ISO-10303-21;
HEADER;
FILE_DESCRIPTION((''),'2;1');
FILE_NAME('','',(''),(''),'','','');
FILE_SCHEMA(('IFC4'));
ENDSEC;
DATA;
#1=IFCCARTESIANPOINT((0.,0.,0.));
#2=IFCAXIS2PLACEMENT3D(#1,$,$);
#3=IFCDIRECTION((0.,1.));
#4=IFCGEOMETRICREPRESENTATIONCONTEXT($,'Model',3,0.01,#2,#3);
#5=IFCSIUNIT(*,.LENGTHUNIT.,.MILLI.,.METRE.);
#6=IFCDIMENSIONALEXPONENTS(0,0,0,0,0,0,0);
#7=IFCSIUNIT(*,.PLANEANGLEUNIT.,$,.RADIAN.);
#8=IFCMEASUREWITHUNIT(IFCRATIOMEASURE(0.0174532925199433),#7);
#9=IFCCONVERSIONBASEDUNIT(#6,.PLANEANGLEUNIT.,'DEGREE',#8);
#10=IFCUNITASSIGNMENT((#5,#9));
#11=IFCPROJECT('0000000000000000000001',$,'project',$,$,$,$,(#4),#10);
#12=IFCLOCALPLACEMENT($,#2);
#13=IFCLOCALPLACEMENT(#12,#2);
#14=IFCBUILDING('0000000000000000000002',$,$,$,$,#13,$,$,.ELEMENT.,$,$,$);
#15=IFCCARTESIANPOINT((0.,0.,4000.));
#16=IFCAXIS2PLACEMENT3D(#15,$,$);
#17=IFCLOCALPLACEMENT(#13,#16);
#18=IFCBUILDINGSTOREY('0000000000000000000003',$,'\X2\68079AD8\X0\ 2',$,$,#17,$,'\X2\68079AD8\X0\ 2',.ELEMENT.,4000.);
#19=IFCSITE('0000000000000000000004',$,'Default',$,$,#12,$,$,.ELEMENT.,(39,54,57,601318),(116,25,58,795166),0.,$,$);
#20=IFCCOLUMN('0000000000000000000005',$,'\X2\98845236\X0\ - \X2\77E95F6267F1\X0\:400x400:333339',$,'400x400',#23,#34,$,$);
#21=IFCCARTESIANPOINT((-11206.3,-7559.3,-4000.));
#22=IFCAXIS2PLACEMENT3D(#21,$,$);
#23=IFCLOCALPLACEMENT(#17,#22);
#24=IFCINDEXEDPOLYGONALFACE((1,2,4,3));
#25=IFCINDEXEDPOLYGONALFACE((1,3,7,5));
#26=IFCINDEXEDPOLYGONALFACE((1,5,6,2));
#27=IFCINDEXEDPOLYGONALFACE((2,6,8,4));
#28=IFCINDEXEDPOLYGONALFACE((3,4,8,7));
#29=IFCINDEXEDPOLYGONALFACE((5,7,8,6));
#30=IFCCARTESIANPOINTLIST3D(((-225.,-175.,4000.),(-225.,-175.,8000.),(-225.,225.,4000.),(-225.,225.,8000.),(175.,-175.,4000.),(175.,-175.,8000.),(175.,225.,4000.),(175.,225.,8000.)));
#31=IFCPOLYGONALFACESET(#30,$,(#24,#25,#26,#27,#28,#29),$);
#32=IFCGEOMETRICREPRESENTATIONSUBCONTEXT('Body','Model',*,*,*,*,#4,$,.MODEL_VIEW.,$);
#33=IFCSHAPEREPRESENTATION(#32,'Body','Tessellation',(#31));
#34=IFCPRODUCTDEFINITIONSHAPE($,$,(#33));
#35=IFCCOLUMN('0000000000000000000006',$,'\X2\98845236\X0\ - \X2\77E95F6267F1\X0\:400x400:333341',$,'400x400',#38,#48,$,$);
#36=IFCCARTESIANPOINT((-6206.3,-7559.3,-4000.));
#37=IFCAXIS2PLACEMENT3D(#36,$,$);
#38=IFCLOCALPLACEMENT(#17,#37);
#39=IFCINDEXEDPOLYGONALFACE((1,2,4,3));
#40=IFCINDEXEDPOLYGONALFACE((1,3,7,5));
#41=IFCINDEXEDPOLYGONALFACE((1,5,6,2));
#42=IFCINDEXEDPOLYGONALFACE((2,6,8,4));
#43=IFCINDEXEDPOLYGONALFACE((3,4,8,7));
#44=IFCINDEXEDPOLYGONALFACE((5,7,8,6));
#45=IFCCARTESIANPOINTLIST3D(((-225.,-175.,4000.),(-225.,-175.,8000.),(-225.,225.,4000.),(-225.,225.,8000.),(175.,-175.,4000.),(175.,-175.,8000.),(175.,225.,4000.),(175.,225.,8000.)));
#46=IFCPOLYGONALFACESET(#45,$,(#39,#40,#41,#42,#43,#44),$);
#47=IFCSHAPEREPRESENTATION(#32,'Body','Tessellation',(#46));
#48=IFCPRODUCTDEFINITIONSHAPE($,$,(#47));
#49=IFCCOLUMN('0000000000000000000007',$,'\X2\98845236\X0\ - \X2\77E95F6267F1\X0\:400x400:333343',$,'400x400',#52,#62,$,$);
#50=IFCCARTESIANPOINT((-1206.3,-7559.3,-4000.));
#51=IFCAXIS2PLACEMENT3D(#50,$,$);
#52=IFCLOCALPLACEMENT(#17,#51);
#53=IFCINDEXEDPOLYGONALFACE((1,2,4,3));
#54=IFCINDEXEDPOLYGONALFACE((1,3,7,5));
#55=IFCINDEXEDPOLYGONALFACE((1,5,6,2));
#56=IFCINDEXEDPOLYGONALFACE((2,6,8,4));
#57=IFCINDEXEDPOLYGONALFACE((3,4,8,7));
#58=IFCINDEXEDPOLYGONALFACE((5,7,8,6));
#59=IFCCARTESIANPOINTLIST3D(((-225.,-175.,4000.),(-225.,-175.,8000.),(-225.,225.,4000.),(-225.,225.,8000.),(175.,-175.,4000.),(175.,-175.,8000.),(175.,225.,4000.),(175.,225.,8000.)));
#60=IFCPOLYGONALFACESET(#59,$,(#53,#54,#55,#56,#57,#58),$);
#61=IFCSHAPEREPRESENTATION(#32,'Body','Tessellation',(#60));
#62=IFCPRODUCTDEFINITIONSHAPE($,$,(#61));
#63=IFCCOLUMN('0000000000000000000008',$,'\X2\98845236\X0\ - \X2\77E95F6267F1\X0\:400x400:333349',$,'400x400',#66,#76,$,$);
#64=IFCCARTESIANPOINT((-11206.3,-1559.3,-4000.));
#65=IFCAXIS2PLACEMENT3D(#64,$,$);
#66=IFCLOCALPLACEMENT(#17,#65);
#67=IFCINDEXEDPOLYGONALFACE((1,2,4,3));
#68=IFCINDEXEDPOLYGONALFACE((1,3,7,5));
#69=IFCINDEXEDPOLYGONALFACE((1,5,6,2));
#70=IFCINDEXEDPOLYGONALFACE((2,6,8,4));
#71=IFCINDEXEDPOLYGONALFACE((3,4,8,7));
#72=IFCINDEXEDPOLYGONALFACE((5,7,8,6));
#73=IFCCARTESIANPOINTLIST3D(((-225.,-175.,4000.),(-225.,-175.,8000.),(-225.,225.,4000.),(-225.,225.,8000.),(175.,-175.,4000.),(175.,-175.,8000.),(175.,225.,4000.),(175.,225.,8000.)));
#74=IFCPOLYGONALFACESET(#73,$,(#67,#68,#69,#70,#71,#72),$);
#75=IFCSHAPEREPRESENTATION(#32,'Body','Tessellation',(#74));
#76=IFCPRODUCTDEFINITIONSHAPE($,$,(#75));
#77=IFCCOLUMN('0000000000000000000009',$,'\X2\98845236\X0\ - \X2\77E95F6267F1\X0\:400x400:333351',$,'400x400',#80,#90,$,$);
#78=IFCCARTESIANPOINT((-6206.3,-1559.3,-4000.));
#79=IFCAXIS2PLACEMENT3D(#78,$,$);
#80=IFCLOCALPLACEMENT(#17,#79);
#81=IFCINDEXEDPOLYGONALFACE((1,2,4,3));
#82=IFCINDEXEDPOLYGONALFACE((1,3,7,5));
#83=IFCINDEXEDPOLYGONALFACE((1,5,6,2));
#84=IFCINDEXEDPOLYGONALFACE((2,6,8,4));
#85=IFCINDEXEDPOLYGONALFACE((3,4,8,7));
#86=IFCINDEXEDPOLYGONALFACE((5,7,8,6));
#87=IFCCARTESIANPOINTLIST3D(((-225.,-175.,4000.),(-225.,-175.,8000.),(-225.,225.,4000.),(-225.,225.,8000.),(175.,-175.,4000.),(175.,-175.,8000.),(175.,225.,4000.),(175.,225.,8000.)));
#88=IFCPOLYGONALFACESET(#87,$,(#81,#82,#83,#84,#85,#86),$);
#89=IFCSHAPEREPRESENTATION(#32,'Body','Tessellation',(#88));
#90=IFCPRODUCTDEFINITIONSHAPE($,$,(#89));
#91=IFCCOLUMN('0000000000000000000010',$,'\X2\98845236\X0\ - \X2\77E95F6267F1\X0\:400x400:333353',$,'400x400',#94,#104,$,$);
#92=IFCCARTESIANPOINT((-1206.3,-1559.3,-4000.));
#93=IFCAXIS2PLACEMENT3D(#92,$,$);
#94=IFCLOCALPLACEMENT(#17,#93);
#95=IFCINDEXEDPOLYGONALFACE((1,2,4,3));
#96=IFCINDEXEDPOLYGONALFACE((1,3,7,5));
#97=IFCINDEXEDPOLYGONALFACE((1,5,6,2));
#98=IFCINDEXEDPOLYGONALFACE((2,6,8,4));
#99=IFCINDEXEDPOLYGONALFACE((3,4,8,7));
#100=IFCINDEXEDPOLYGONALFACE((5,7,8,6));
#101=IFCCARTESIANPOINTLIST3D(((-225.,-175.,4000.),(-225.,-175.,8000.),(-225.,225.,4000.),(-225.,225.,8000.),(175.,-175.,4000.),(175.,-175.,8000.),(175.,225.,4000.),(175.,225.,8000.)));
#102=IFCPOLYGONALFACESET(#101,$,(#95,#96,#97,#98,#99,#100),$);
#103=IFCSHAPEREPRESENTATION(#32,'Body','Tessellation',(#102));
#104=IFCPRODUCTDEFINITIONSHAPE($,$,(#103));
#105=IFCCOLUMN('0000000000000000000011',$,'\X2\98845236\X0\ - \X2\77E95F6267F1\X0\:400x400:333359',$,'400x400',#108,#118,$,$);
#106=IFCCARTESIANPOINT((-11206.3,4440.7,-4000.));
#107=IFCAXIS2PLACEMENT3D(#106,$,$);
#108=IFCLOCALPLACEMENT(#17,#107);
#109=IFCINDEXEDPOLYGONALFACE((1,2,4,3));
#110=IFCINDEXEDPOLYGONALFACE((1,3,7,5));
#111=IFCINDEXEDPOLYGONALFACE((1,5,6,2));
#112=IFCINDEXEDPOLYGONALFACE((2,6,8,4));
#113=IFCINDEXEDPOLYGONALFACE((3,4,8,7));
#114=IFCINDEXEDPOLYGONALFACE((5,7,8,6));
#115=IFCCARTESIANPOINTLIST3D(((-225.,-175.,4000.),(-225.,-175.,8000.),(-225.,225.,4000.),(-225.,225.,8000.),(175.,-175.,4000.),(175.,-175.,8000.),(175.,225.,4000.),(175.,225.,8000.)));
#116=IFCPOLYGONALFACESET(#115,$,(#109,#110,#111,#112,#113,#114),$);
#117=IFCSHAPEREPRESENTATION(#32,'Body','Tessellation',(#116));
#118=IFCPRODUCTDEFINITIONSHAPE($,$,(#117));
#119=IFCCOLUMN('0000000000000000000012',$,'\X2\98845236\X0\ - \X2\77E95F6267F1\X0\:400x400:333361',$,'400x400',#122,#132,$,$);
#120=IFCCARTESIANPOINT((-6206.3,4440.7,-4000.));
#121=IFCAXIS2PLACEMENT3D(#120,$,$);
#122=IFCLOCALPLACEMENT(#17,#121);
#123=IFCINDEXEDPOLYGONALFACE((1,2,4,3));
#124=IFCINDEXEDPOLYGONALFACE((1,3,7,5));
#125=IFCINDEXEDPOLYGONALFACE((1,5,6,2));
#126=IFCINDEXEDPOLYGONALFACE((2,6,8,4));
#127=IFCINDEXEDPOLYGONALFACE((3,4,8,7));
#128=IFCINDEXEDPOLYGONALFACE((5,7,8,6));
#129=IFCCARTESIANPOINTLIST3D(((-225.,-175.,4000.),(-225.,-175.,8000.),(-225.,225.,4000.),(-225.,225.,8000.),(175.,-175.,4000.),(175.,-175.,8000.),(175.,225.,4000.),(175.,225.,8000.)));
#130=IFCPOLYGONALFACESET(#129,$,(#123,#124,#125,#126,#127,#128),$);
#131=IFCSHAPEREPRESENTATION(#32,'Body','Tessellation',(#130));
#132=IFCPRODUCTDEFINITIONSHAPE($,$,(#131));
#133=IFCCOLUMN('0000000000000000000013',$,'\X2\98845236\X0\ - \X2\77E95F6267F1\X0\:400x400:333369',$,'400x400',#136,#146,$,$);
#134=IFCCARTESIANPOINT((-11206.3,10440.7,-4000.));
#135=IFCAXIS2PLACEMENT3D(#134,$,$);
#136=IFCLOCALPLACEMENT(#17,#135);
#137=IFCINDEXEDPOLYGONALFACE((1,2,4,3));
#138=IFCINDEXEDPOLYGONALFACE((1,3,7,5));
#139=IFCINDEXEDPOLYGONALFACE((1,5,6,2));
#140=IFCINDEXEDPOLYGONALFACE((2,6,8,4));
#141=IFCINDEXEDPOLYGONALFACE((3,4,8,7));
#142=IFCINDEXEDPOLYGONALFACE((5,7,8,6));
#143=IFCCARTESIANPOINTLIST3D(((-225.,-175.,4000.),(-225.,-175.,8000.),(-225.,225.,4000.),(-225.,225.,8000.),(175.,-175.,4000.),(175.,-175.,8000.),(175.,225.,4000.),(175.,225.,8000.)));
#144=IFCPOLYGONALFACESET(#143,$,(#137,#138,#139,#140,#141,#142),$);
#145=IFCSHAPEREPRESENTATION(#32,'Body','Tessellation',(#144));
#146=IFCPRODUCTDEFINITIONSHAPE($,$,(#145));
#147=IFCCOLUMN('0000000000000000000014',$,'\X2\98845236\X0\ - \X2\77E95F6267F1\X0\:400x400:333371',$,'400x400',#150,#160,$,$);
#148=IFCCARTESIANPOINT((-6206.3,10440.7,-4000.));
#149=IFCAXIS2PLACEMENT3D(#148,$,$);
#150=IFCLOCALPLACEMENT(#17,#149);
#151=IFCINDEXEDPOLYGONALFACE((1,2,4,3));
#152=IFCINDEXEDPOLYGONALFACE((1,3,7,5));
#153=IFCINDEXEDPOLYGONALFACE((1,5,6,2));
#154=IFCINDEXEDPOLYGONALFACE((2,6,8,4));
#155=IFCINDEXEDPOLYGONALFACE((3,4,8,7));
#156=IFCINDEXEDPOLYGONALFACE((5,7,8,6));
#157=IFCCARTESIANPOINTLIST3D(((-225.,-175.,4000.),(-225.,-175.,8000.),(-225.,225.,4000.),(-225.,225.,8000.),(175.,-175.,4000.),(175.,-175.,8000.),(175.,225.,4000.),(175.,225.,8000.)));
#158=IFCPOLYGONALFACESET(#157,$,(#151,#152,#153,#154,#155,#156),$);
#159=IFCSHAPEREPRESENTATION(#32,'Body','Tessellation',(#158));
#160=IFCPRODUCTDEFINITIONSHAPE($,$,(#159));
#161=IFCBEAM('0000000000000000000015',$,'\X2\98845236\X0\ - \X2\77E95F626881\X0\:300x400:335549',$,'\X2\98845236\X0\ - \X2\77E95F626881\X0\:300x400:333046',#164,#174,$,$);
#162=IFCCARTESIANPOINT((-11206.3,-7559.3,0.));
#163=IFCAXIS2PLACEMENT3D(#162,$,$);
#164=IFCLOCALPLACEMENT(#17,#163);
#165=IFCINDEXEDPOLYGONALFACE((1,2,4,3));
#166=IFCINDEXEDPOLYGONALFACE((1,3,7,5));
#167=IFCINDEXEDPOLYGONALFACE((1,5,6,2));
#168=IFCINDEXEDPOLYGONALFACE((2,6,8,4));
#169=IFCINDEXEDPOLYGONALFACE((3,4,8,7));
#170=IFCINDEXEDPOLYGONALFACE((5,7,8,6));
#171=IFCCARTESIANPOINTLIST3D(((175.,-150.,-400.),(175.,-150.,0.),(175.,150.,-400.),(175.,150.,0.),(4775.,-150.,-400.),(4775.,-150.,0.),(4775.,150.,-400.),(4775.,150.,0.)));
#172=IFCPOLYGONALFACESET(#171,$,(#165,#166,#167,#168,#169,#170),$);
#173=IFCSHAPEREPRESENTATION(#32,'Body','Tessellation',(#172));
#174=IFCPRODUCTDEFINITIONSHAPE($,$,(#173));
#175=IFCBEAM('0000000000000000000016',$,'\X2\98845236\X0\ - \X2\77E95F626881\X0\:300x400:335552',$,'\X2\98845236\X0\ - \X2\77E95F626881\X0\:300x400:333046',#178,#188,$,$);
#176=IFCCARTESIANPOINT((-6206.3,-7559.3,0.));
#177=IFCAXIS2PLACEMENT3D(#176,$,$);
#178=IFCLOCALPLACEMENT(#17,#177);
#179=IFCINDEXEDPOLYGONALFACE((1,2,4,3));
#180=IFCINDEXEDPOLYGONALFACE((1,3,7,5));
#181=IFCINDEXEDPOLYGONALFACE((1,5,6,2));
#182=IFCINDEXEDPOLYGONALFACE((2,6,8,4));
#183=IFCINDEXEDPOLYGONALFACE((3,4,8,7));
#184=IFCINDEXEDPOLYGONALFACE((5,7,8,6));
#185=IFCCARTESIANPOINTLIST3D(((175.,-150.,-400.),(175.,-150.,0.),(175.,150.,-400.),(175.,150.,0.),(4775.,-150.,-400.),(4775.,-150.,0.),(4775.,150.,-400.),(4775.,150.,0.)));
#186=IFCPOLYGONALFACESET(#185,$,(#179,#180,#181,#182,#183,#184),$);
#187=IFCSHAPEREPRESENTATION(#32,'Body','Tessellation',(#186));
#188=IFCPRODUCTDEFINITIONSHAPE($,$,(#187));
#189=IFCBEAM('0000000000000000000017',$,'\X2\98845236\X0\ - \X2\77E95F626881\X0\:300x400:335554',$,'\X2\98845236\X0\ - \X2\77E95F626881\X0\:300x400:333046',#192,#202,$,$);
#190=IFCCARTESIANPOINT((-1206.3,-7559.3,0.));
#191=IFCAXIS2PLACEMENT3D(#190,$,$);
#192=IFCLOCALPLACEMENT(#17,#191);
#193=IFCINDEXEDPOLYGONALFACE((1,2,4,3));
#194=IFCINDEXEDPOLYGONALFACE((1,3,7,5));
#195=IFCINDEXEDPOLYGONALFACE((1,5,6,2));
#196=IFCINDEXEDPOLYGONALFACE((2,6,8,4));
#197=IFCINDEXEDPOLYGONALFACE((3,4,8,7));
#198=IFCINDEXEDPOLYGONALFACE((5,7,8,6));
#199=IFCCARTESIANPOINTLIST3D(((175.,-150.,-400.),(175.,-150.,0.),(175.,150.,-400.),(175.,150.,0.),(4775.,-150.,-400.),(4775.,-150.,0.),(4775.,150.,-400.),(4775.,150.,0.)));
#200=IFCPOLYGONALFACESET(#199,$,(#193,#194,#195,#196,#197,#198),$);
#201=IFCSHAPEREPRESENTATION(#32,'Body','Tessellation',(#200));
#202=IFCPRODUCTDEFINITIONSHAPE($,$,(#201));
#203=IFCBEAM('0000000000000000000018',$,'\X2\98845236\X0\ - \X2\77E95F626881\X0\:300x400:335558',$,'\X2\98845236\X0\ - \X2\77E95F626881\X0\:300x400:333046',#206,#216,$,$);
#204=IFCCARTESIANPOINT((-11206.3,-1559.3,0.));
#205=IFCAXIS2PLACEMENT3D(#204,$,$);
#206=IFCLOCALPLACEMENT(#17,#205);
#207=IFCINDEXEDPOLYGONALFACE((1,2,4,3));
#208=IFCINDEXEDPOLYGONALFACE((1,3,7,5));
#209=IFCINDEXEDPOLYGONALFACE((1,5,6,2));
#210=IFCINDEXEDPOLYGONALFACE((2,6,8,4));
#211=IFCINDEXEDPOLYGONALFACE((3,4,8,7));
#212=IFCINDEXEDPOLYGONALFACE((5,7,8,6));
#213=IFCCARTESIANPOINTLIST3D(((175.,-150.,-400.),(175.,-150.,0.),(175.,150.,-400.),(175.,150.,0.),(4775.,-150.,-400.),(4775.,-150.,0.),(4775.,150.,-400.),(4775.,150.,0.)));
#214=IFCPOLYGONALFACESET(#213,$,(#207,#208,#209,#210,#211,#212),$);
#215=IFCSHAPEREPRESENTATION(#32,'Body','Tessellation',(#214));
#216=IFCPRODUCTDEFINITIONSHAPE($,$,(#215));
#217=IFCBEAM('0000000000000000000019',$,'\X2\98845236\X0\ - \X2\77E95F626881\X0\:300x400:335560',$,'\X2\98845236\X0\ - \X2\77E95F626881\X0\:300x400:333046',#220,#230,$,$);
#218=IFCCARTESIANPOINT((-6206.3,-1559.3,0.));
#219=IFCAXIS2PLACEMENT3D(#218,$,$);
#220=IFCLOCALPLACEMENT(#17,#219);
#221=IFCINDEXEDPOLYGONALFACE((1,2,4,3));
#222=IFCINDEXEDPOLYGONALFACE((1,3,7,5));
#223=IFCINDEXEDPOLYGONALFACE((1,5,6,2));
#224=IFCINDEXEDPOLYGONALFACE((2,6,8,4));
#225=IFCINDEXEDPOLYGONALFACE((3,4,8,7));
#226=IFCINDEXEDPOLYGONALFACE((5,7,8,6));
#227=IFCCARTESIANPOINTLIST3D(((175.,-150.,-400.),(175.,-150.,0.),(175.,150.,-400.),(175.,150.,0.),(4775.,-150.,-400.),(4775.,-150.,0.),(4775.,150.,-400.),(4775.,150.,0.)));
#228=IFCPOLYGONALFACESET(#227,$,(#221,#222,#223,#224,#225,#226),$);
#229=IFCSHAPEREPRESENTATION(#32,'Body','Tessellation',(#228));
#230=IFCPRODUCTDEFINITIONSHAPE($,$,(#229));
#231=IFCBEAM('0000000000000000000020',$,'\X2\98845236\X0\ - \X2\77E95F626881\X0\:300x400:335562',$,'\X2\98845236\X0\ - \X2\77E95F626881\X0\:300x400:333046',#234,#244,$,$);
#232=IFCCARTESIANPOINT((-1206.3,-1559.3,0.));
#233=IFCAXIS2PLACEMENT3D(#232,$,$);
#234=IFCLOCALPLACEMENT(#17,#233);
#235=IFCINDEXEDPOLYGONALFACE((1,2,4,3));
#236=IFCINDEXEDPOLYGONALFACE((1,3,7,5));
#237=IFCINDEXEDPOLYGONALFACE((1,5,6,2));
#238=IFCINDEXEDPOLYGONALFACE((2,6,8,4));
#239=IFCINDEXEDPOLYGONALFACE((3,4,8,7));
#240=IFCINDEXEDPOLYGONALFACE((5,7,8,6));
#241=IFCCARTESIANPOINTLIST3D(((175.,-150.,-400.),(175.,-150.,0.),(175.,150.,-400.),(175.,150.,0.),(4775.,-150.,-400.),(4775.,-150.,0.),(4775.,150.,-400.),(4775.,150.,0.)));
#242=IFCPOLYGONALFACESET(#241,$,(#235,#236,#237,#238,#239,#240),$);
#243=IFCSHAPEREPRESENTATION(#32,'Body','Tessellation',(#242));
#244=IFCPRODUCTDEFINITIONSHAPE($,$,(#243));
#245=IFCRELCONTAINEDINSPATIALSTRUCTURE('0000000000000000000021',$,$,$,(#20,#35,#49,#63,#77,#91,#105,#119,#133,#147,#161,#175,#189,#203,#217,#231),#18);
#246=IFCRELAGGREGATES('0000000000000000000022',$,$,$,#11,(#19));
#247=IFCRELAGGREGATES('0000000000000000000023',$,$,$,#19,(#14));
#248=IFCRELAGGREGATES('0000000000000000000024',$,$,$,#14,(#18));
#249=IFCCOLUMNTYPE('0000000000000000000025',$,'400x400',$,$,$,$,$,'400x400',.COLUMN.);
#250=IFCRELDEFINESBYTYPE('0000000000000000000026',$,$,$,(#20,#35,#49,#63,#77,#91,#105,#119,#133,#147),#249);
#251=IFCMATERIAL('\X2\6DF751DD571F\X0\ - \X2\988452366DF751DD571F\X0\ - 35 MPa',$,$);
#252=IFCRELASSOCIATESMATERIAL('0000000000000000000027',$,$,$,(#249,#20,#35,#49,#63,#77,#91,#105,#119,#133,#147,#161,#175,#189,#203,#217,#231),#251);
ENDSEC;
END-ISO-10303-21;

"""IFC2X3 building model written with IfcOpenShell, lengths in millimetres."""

from ifc_helpers import new_model, entity, si_unit, converted_unit, direction, frame, frame_2d, origin, place, context, subcontext, project, spatial, rectangle, extrude, source, transform, mapped, material, type_object, type_shapes, element, save


model = new_model("IFC2X3")

# Units and contexts
model_context = context("Model", 3, precision=0.01, world=origin(), true_north=direction((0.0, 1.0)))
body_context = subcontext(model_context, "Body", "Model", "MODEL_VIEW")
ifc_project = project(units=[si_unit("LENGTHUNIT", "METRE", prefix="MILLI"), converted_unit("PLANEANGLEUNIT", "DEGREE", entity("IfcRatioMeasure", 0.0174532925199433), si_unit("PLANEANGLEUNIT", "RADIAN"), dimensions=[0, 0, 0, 0, 0, 0, 0])], contexts=[model_context])

# Site, building, storey
site_placement = place(None, origin())
site = spatial("IfcSite", under=ifc_project, at=site_placement, Name="Default", CompositionType="ELEMENT", RefLatitude=(39, 54, 57, 601318), RefLongitude=(116, 25, 58, 795166), RefElevation=0.0)
building_placement = place(site_placement, origin())
building = spatial("IfcBuilding", under=site, at=building_placement, CompositionType="ELEMENT")
storey_placement = place(building_placement, frame((0.0, 0.0, 4000.0)))
storey = spatial("IfcBuildingStorey", under=building, at=storey_placement, Name="标高 2", LongName="标高 2", CompositionType="ELEMENT", Elevation=4000.0)

# Columns
ifc_material = material(Name="混凝土 - 预制混凝土 - 35 MPa")
column_type = type_object("IfcColumnType", Name="400x400", ElementType="400x400", PredefinedType="COLUMN", material=ifc_material)
shared_shape = source(origin(), body_context, "Body", "SweptSolid", [
    extrude(rectangle(XDim=400.0, YDim=400.0, at=frame_2d((0.0, 0.0), x_axis=(1.0, 0.0))), frame((-25.0, 25.0, 4000.0)), (0.0, 0.0, 1.0), 4000.0),
])
type_shapes(column_type, [shared_shape])
for number, where, name in (
    (1, (-11206.3, -7559.3, -4000.0), "预制 - 矩形柱:400x400:333339"),
    (2, (-6206.3, -7559.3, -4000.0), "预制 - 矩形柱:400x400:333341"),
    (3, (-1206.3, -7559.3, -4000.0), "预制 - 矩形柱:400x400:333343"),
    (4, (-11206.3, -1559.3, -4000.0), "预制 - 矩形柱:400x400:333349"),
    (5, (-6206.3, -1559.3, -4000.0), "预制 - 矩形柱:400x400:333351"),
    (6, (-1206.3, -1559.3, -4000.0), "预制 - 矩形柱:400x400:333353"),
    (7, (-11206.3, 4440.7, -4000.0), "预制 - 矩形柱:400x400:333359"),
    (8, (-6206.3, 4440.7, -4000.0), "预制 - 矩形柱:400x400:333361"),
    (9, (-11206.3, 10440.7, -4000.0), "预制 - 矩形柱:400x400:333369"),
    (10, (-6206.3, 10440.7, -4000.0), "预制 - 矩形柱:400x400:333371"),
):
    element("IfcColumn", number, at=place(storey_placement, frame(where)), inside=storey, type_object=column_type, material=ifc_material, Name=name, ObjectType="400x400", context=body_context, shape_type="MappedRepresentation", body=[
        mapped(shared_shape, transform((0.0, 0.0, 0.0), scale=1.0)),
    ])

# Beams
for number, where, name in (
    (11, (-11206.3, -7559.3, 0.0), "预制 - 矩形梁:300x400:335549"),
    (12, (-6206.3, -7559.3, 0.0), "预制 - 矩形梁:300x400:335552"),
):
    element("IfcBeam", number, at=place(storey_placement, frame(where)), inside=storey, material=ifc_material, Name=name, ObjectType="预制 - 矩形梁:300x400:333046", context=body_context, shape_type="SweptSolid", body=[
        extrude(rectangle(XDim=400.0, YDim=300.0, at=frame_2d((0.0, 0.0), x_axis=(1.0, 0.0))), frame((175.0, 0.0, -200.0), z_axis=(1.0, 0.0, 0.0), x_axis=(0.0, 0.0, -1.0)), (0.0, 0.0, 1.0), 4600.0),
    ])
beam_1_placement = place(storey_placement, frame((-1206.3, -7559.3, 0.0)))
element("IfcBeam", 13, at=beam_1_placement, inside=storey, material=ifc_material, Name="预制 - 矩形梁:300x400:335554", ObjectType="预制 - 矩形梁:300x400:333046", context=body_context, shape_type="SweptSolid", body=[
    extrude(rectangle(XDim=400.0, YDim=300.0, at=frame_2d((0.0, 0.0), x_axis=(1.0, 0.0))), frame((175.0, 0.0, -200.0), z_axis=(1.0, 0.0, 0.0), x_axis=(0.0, 0.0, -1.0)), (0.0, 0.0, 1.0), 4600.0),
])
for number, where, name in (
    (14, (-11206.3, -1559.3, 0.0), "预制 - 矩形梁:300x400:335558"),
    (15, (-6206.3, -1559.3, 0.0), "预制 - 矩形梁:300x400:335560"),
):
    element("IfcBeam", number, at=place(storey_placement, frame(where)), inside=storey, material=ifc_material, Name=name, ObjectType="预制 - 矩形梁:300x400:333046", context=body_context, shape_type="SweptSolid", body=[
        extrude(rectangle(XDim=400.0, YDim=300.0, at=frame_2d((0.0, 0.0), x_axis=(1.0, 0.0))), frame((175.0, 0.0, -200.0), z_axis=(1.0, 0.0, 0.0), x_axis=(0.0, 0.0, -1.0)), (0.0, 0.0, 1.0), 4600.0),
    ])
beam_2_placement = place(storey_placement, frame((-1206.3, -1559.3, 0.0)))
element("IfcBeam", 16, at=beam_2_placement, inside=storey, material=ifc_material, Name="预制 - 矩形梁:300x400:335562", ObjectType="预制 - 矩形梁:300x400:333046", context=body_context, shape_type="SweptSolid", body=[
    extrude(rectangle(XDim=400.0, YDim=300.0, at=frame_2d((0.0, 0.0), x_axis=(1.0, 0.0))), frame((175.0, 0.0, -200.0), z_axis=(1.0, 0.0, 0.0), x_axis=(0.0, 0.0, -1.0)), (0.0, 0.0, 1.0), 4600.0),
])

save(model, "model.ifc")
